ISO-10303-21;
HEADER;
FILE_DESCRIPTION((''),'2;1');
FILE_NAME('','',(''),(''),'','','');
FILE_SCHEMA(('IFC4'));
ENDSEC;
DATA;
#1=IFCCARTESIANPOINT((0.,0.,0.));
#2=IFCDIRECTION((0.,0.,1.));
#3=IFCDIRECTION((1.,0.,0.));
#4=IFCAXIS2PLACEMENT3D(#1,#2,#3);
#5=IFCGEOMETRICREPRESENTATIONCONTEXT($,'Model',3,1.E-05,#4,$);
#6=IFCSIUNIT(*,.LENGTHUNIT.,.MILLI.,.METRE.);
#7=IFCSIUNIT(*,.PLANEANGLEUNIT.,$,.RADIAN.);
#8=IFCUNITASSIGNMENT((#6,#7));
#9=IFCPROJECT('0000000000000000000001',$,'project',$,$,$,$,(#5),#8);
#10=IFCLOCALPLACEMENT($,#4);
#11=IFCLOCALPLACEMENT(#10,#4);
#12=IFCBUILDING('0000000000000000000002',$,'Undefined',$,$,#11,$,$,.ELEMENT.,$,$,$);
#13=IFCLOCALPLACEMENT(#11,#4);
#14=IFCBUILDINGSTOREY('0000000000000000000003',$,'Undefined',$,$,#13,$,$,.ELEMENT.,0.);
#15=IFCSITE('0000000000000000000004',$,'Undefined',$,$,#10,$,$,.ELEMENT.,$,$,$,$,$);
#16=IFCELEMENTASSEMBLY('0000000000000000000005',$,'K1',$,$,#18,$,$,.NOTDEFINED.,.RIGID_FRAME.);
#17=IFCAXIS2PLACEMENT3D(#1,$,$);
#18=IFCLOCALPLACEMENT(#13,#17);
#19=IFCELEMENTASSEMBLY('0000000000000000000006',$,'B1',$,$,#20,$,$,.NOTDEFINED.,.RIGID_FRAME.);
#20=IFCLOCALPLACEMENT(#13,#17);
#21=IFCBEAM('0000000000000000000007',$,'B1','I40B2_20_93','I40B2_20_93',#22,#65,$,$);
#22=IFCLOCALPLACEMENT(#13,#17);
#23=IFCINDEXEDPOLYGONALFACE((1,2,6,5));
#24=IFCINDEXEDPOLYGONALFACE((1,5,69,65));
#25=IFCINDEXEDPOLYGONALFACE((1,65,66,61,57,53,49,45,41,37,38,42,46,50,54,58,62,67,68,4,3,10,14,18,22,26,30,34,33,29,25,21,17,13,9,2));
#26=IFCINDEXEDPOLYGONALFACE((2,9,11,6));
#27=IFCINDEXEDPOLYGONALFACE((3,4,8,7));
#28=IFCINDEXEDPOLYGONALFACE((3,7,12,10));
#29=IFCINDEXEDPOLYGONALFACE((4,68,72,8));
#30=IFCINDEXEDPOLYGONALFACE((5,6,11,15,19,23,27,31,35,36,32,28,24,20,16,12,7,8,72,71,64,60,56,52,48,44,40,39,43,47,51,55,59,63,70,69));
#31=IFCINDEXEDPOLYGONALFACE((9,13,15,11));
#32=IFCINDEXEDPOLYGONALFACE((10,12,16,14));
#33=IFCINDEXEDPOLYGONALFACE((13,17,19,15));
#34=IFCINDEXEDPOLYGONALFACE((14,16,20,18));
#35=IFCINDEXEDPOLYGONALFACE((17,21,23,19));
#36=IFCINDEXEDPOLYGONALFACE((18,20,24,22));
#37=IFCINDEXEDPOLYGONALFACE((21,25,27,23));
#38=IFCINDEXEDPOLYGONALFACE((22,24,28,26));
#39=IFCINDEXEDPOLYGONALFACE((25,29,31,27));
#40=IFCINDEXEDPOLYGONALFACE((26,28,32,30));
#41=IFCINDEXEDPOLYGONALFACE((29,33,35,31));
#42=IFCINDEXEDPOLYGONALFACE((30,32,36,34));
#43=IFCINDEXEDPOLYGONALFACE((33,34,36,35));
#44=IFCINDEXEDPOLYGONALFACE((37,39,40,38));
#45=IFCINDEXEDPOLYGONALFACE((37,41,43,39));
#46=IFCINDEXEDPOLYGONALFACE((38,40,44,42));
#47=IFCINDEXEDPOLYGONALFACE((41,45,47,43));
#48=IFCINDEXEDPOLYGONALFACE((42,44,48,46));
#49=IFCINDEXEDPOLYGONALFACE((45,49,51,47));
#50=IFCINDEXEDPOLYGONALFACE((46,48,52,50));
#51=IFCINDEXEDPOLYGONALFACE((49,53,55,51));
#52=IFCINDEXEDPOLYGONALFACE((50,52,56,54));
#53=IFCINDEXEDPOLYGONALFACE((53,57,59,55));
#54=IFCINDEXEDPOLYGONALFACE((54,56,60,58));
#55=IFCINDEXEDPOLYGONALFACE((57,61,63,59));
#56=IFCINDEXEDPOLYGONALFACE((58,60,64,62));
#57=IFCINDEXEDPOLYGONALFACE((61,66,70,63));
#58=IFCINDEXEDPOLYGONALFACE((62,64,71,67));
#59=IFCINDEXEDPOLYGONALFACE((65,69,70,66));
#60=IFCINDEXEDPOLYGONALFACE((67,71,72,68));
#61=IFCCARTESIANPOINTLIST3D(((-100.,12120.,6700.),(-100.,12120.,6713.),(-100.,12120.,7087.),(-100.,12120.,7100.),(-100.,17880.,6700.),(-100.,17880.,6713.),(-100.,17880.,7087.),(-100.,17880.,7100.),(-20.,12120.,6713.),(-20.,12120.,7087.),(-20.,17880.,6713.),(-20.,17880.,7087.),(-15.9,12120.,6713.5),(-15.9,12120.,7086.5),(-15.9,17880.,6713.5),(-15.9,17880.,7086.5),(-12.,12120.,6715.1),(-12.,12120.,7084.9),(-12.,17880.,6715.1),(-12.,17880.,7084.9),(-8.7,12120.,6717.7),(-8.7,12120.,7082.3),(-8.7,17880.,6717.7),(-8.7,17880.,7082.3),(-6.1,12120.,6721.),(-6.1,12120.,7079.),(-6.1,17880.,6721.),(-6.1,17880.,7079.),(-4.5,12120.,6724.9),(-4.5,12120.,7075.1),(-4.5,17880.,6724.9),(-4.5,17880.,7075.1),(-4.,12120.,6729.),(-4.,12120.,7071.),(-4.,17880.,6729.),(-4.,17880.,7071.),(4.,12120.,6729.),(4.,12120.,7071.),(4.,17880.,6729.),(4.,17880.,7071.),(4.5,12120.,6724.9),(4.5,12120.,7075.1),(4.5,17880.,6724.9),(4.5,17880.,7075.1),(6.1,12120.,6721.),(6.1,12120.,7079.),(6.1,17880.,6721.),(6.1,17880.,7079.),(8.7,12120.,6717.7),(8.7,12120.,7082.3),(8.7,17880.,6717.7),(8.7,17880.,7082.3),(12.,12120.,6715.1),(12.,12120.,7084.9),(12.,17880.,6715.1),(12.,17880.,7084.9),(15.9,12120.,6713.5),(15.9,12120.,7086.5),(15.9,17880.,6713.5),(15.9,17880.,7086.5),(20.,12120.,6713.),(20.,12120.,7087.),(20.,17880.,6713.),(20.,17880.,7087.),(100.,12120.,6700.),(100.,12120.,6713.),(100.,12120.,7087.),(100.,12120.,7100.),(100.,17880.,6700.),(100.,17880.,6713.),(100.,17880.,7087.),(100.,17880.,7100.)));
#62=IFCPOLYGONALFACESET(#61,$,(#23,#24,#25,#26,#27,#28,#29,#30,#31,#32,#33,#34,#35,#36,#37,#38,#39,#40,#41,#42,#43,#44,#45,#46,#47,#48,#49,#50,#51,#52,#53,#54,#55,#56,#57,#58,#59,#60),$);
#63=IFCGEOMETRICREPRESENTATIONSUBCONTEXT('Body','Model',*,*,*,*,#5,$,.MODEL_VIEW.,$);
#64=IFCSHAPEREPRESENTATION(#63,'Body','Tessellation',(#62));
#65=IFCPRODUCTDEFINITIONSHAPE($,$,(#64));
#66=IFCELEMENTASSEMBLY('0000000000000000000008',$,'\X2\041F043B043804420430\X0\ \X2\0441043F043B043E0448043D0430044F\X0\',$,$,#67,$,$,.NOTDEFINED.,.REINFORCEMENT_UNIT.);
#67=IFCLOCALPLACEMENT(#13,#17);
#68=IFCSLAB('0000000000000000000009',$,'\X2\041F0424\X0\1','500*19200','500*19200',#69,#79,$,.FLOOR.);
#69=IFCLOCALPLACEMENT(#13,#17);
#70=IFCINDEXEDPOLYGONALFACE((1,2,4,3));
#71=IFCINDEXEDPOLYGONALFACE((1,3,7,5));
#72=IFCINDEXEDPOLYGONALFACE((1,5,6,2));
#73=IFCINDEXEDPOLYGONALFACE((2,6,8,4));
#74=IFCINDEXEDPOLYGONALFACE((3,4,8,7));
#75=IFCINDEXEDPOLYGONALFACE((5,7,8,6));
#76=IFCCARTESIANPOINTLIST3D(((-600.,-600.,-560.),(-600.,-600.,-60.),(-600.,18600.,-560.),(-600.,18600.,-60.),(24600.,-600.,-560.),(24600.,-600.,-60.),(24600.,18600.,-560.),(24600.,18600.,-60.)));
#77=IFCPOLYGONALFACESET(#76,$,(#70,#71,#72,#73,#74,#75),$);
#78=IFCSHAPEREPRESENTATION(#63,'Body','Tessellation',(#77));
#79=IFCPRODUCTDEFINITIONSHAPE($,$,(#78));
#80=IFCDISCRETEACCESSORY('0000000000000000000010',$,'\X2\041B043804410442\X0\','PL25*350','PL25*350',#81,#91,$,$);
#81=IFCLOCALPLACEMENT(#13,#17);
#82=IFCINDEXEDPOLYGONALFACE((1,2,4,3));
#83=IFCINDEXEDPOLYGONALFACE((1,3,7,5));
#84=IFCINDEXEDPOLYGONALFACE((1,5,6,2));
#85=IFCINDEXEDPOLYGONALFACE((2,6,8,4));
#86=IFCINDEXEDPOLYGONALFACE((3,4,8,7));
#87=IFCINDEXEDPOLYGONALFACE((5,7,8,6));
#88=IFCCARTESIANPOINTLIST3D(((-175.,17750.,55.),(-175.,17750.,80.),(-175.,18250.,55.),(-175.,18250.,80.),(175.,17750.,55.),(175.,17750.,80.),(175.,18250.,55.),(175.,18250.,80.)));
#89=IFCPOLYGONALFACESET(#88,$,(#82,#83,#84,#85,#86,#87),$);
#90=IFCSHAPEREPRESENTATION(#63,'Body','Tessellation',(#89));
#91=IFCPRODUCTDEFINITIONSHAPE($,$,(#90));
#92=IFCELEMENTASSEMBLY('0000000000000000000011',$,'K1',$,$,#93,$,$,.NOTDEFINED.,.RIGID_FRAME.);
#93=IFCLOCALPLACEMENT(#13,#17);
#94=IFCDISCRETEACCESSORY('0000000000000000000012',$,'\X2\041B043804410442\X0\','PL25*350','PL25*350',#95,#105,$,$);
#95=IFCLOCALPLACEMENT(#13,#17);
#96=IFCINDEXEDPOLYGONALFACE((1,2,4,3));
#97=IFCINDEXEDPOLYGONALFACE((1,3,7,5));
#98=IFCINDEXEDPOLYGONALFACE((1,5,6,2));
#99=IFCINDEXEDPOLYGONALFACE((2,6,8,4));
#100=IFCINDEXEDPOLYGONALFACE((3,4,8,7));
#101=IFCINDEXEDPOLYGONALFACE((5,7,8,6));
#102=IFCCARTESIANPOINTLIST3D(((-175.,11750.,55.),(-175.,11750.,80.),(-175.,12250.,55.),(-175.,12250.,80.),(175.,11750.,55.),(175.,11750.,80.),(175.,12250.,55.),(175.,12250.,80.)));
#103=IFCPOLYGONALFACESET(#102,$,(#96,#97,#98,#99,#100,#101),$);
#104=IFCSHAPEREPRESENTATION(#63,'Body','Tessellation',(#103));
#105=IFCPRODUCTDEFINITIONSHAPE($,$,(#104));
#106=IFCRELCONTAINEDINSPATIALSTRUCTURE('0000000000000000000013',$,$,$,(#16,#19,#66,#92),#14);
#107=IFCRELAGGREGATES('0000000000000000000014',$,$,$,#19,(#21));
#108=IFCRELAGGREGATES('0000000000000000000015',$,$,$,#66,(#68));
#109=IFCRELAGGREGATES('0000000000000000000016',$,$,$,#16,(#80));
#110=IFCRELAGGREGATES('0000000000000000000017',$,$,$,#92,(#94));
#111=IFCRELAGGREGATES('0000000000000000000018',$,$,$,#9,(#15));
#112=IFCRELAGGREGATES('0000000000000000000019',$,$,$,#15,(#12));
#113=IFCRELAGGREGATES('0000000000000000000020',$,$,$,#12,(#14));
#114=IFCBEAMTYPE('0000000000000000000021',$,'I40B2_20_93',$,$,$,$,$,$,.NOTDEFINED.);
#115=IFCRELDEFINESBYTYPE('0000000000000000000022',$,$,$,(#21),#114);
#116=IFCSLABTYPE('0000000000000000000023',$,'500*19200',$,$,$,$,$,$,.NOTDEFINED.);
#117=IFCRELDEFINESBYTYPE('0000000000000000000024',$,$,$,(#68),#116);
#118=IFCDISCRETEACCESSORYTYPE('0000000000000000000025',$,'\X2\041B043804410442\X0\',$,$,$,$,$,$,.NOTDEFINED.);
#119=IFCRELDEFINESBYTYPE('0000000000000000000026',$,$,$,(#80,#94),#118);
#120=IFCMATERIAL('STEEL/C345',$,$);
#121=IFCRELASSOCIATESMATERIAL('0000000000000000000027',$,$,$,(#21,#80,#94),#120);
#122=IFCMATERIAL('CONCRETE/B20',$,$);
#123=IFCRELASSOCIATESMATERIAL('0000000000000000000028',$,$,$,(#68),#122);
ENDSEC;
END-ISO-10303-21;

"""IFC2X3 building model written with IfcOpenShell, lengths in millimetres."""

from ifc_helpers import new_model, si_unit, frame, origin_with_axes, origin_2d_with_axis, place, context, subcontext, project, spatial, polyline, i_section, outline, extrude, material, type_object, element, aggregate, save


model = new_model("IFC2X3")

# Units and contexts
model_context = context("Model", 3, precision=1e-05, world=origin_with_axes())
body_context = subcontext(model_context, "Body", "Model", "MODEL_VIEW")
ifc_project = project(units=[si_unit("LENGTHUNIT", "METRE", prefix="MILLI"), si_unit("PLANEANGLEUNIT", "RADIAN")], contexts=[model_context])

# Site, building, storey
site_placement = place(None, origin_with_axes())
site = spatial("IfcSite", under=ifc_project, at=site_placement, Name="Undefined", CompositionType="ELEMENT")
building_placement = place(site_placement, origin_with_axes())
building = spatial("IfcBuilding", under=site, at=building_placement, Name="Undefined", CompositionType="ELEMENT")
storey_placement = place(building_placement, origin_with_axes())
storey = spatial("IfcBuildingStorey", under=building, at=storey_placement, Name="Undefined", CompositionType="ELEMENT", Elevation=0.0)

# Element assembly
assembly_1_placement = place(storey_placement, origin_with_axes())
assembly_1 = element("IfcElementAssembly", 1, at=assembly_1_placement, inside=storey, Name="K1", AssemblyPlace="NOTDEFINED", PredefinedType="RIGID_FRAME")
ifc_material_1 = material(Name="STEEL/C345")

# Element assembly, beam
assembly_2_placement = place(storey_placement, origin_with_axes())
assembly_2 = element("IfcElementAssembly", 2, at=assembly_2_placement, inside=storey, Name="B1", AssemblyPlace="NOTDEFINED", PredefinedType="RIGID_FRAME")
beam_type_1 = type_object("IfcBeamType", Name="I40B2_20_93", PredefinedType="NOTDEFINED")
beam_1_placement = place(assembly_2_placement, frame((0.0, 12120.0, 6900.0), z_axis=(0.0, 0.0, 1.0), x_axis=(0.0, 1.0, 0.0)))
beam_1 = element("IfcBeam", 3, at=beam_1_placement, type_object=beam_type_1, material=ifc_material_1, Name="B1", Description="I40B2_20_93", ObjectType="I40B2_20_93", context=body_context, shape_type="SweptSolid", body=[
    extrude(i_section(OverallWidth=200.0, OverallDepth=400.0, WebThickness=8.0, FlangeThickness=13.0, FilletRadius=16.0, at=origin_2d_with_axis()), frame((5760.0, 0.0, 0.0), z_axis=(-1.0, 0.0, 0.0), x_axis=(0.0, -1.0, 0.0)), (0.0, 0.0, 1.0), 5760.0),
])
aggregate(assembly_2, [beam_1])

# Element assembly, slab
assembly_3_placement = place(storey_placement, origin_with_axes())
assembly_3 = element("IfcElementAssembly", 4, at=assembly_3_placement, inside=storey, Name="Плита сплошная", AssemblyPlace="NOTDEFINED", PredefinedType="REINFORCEMENT_UNIT")
ifc_material_2 = material(Name="CONCRETE/B20")
slab_type = type_object("IfcSlabType", Name="500*19200", PredefinedType="NOTDEFINED")
slab_placement = place(assembly_3_placement, frame((-600.0, 18600.0, -310.0), z_axis=(0.0, 0.0, 1.0), x_axis=(0.0, -1.0, 0.0)))
slab = element("IfcSlab", 5, at=slab_placement, type_object=slab_type, material=ifc_material_2, Name="ПФ1", Description="500*19200", ObjectType="500*19200", PredefinedType="FLOOR", context=body_context, shape_type="SweptSolid", body=[
    extrude(outline(polyline([(0.0, 0.0), (19200.0, 0.0), (19200.0, 25200.0), (0.0, 25200.0), (0.0, 0.0)])), frame((0.0, 0.0, -250.0), z_axis=(0.0, 0.0, 1.0), x_axis=(1.0, 0.0, 0.0)), (0.0, 0.0, 1.0), 500.0),
])
aggregate(assembly_3, [slab])

# Discrete accessory
discrete_accessory_type = type_object("IfcDiscreteAccessoryType", Name="Лист")
discrete_accessory_1_placement = place(assembly_1_placement, frame((-175.0, 18250.0, 67.5), z_axis=(0.0, 0.0, 1.0), x_axis=(0.0, -1.0, 0.0)))
discrete_accessory_1 = element("IfcDiscreteAccessory", 6, at=discrete_accessory_1_placement, type_object=discrete_accessory_type, material=ifc_material_1, Name="Лист", Description="PL25*350", ObjectType="PL25*350", context=body_context, shape_type="SweptSolid", body=[
    extrude(outline(polyline([(0.0, 0.0), (500.0, 0.0), (500.0, 350.0), (0.0, 350.0), (0.0, 0.0)])), frame((0.0, 0.0, -12.5), z_axis=(0.0, 0.0, 1.0), x_axis=(1.0, 0.0, 0.0)), (0.0, 0.0, 1.0), 25.0),
])
aggregate(assembly_1, [discrete_accessory_1])

# Element assembly, discrete accessory
assembly_4_placement = place(storey_placement, origin_with_axes())
assembly_4 = element("IfcElementAssembly", 7, at=assembly_4_placement, inside=storey, Name="K1", AssemblyPlace="NOTDEFINED", PredefinedType="RIGID_FRAME")
discrete_accessory_2_placement = place(assembly_4_placement, frame((-175.0, 12250.0, 67.5), z_axis=(0.0, 0.0, 1.0), x_axis=(0.0, -1.0, 0.0)))
discrete_accessory_2 = element("IfcDiscreteAccessory", 8, at=discrete_accessory_2_placement, type_object=discrete_accessory_type, material=ifc_material_1, Name="Лист", Description="PL25*350", ObjectType="PL25*350", context=body_context, shape_type="SweptSolid", body=[
    extrude(outline(polyline([(0.0, 0.0), (500.0, 0.0), (500.0, 350.0), (0.0, 350.0), (0.0, 0.0)])), frame((0.0, 0.0, -12.5), z_axis=(0.0, 0.0, 1.0), x_axis=(1.0, 0.0, 0.0)), (0.0, 0.0, 1.0), 25.0),
])
aggregate(assembly_4, [discrete_accessory_2])

save(model, "model.ifc")
